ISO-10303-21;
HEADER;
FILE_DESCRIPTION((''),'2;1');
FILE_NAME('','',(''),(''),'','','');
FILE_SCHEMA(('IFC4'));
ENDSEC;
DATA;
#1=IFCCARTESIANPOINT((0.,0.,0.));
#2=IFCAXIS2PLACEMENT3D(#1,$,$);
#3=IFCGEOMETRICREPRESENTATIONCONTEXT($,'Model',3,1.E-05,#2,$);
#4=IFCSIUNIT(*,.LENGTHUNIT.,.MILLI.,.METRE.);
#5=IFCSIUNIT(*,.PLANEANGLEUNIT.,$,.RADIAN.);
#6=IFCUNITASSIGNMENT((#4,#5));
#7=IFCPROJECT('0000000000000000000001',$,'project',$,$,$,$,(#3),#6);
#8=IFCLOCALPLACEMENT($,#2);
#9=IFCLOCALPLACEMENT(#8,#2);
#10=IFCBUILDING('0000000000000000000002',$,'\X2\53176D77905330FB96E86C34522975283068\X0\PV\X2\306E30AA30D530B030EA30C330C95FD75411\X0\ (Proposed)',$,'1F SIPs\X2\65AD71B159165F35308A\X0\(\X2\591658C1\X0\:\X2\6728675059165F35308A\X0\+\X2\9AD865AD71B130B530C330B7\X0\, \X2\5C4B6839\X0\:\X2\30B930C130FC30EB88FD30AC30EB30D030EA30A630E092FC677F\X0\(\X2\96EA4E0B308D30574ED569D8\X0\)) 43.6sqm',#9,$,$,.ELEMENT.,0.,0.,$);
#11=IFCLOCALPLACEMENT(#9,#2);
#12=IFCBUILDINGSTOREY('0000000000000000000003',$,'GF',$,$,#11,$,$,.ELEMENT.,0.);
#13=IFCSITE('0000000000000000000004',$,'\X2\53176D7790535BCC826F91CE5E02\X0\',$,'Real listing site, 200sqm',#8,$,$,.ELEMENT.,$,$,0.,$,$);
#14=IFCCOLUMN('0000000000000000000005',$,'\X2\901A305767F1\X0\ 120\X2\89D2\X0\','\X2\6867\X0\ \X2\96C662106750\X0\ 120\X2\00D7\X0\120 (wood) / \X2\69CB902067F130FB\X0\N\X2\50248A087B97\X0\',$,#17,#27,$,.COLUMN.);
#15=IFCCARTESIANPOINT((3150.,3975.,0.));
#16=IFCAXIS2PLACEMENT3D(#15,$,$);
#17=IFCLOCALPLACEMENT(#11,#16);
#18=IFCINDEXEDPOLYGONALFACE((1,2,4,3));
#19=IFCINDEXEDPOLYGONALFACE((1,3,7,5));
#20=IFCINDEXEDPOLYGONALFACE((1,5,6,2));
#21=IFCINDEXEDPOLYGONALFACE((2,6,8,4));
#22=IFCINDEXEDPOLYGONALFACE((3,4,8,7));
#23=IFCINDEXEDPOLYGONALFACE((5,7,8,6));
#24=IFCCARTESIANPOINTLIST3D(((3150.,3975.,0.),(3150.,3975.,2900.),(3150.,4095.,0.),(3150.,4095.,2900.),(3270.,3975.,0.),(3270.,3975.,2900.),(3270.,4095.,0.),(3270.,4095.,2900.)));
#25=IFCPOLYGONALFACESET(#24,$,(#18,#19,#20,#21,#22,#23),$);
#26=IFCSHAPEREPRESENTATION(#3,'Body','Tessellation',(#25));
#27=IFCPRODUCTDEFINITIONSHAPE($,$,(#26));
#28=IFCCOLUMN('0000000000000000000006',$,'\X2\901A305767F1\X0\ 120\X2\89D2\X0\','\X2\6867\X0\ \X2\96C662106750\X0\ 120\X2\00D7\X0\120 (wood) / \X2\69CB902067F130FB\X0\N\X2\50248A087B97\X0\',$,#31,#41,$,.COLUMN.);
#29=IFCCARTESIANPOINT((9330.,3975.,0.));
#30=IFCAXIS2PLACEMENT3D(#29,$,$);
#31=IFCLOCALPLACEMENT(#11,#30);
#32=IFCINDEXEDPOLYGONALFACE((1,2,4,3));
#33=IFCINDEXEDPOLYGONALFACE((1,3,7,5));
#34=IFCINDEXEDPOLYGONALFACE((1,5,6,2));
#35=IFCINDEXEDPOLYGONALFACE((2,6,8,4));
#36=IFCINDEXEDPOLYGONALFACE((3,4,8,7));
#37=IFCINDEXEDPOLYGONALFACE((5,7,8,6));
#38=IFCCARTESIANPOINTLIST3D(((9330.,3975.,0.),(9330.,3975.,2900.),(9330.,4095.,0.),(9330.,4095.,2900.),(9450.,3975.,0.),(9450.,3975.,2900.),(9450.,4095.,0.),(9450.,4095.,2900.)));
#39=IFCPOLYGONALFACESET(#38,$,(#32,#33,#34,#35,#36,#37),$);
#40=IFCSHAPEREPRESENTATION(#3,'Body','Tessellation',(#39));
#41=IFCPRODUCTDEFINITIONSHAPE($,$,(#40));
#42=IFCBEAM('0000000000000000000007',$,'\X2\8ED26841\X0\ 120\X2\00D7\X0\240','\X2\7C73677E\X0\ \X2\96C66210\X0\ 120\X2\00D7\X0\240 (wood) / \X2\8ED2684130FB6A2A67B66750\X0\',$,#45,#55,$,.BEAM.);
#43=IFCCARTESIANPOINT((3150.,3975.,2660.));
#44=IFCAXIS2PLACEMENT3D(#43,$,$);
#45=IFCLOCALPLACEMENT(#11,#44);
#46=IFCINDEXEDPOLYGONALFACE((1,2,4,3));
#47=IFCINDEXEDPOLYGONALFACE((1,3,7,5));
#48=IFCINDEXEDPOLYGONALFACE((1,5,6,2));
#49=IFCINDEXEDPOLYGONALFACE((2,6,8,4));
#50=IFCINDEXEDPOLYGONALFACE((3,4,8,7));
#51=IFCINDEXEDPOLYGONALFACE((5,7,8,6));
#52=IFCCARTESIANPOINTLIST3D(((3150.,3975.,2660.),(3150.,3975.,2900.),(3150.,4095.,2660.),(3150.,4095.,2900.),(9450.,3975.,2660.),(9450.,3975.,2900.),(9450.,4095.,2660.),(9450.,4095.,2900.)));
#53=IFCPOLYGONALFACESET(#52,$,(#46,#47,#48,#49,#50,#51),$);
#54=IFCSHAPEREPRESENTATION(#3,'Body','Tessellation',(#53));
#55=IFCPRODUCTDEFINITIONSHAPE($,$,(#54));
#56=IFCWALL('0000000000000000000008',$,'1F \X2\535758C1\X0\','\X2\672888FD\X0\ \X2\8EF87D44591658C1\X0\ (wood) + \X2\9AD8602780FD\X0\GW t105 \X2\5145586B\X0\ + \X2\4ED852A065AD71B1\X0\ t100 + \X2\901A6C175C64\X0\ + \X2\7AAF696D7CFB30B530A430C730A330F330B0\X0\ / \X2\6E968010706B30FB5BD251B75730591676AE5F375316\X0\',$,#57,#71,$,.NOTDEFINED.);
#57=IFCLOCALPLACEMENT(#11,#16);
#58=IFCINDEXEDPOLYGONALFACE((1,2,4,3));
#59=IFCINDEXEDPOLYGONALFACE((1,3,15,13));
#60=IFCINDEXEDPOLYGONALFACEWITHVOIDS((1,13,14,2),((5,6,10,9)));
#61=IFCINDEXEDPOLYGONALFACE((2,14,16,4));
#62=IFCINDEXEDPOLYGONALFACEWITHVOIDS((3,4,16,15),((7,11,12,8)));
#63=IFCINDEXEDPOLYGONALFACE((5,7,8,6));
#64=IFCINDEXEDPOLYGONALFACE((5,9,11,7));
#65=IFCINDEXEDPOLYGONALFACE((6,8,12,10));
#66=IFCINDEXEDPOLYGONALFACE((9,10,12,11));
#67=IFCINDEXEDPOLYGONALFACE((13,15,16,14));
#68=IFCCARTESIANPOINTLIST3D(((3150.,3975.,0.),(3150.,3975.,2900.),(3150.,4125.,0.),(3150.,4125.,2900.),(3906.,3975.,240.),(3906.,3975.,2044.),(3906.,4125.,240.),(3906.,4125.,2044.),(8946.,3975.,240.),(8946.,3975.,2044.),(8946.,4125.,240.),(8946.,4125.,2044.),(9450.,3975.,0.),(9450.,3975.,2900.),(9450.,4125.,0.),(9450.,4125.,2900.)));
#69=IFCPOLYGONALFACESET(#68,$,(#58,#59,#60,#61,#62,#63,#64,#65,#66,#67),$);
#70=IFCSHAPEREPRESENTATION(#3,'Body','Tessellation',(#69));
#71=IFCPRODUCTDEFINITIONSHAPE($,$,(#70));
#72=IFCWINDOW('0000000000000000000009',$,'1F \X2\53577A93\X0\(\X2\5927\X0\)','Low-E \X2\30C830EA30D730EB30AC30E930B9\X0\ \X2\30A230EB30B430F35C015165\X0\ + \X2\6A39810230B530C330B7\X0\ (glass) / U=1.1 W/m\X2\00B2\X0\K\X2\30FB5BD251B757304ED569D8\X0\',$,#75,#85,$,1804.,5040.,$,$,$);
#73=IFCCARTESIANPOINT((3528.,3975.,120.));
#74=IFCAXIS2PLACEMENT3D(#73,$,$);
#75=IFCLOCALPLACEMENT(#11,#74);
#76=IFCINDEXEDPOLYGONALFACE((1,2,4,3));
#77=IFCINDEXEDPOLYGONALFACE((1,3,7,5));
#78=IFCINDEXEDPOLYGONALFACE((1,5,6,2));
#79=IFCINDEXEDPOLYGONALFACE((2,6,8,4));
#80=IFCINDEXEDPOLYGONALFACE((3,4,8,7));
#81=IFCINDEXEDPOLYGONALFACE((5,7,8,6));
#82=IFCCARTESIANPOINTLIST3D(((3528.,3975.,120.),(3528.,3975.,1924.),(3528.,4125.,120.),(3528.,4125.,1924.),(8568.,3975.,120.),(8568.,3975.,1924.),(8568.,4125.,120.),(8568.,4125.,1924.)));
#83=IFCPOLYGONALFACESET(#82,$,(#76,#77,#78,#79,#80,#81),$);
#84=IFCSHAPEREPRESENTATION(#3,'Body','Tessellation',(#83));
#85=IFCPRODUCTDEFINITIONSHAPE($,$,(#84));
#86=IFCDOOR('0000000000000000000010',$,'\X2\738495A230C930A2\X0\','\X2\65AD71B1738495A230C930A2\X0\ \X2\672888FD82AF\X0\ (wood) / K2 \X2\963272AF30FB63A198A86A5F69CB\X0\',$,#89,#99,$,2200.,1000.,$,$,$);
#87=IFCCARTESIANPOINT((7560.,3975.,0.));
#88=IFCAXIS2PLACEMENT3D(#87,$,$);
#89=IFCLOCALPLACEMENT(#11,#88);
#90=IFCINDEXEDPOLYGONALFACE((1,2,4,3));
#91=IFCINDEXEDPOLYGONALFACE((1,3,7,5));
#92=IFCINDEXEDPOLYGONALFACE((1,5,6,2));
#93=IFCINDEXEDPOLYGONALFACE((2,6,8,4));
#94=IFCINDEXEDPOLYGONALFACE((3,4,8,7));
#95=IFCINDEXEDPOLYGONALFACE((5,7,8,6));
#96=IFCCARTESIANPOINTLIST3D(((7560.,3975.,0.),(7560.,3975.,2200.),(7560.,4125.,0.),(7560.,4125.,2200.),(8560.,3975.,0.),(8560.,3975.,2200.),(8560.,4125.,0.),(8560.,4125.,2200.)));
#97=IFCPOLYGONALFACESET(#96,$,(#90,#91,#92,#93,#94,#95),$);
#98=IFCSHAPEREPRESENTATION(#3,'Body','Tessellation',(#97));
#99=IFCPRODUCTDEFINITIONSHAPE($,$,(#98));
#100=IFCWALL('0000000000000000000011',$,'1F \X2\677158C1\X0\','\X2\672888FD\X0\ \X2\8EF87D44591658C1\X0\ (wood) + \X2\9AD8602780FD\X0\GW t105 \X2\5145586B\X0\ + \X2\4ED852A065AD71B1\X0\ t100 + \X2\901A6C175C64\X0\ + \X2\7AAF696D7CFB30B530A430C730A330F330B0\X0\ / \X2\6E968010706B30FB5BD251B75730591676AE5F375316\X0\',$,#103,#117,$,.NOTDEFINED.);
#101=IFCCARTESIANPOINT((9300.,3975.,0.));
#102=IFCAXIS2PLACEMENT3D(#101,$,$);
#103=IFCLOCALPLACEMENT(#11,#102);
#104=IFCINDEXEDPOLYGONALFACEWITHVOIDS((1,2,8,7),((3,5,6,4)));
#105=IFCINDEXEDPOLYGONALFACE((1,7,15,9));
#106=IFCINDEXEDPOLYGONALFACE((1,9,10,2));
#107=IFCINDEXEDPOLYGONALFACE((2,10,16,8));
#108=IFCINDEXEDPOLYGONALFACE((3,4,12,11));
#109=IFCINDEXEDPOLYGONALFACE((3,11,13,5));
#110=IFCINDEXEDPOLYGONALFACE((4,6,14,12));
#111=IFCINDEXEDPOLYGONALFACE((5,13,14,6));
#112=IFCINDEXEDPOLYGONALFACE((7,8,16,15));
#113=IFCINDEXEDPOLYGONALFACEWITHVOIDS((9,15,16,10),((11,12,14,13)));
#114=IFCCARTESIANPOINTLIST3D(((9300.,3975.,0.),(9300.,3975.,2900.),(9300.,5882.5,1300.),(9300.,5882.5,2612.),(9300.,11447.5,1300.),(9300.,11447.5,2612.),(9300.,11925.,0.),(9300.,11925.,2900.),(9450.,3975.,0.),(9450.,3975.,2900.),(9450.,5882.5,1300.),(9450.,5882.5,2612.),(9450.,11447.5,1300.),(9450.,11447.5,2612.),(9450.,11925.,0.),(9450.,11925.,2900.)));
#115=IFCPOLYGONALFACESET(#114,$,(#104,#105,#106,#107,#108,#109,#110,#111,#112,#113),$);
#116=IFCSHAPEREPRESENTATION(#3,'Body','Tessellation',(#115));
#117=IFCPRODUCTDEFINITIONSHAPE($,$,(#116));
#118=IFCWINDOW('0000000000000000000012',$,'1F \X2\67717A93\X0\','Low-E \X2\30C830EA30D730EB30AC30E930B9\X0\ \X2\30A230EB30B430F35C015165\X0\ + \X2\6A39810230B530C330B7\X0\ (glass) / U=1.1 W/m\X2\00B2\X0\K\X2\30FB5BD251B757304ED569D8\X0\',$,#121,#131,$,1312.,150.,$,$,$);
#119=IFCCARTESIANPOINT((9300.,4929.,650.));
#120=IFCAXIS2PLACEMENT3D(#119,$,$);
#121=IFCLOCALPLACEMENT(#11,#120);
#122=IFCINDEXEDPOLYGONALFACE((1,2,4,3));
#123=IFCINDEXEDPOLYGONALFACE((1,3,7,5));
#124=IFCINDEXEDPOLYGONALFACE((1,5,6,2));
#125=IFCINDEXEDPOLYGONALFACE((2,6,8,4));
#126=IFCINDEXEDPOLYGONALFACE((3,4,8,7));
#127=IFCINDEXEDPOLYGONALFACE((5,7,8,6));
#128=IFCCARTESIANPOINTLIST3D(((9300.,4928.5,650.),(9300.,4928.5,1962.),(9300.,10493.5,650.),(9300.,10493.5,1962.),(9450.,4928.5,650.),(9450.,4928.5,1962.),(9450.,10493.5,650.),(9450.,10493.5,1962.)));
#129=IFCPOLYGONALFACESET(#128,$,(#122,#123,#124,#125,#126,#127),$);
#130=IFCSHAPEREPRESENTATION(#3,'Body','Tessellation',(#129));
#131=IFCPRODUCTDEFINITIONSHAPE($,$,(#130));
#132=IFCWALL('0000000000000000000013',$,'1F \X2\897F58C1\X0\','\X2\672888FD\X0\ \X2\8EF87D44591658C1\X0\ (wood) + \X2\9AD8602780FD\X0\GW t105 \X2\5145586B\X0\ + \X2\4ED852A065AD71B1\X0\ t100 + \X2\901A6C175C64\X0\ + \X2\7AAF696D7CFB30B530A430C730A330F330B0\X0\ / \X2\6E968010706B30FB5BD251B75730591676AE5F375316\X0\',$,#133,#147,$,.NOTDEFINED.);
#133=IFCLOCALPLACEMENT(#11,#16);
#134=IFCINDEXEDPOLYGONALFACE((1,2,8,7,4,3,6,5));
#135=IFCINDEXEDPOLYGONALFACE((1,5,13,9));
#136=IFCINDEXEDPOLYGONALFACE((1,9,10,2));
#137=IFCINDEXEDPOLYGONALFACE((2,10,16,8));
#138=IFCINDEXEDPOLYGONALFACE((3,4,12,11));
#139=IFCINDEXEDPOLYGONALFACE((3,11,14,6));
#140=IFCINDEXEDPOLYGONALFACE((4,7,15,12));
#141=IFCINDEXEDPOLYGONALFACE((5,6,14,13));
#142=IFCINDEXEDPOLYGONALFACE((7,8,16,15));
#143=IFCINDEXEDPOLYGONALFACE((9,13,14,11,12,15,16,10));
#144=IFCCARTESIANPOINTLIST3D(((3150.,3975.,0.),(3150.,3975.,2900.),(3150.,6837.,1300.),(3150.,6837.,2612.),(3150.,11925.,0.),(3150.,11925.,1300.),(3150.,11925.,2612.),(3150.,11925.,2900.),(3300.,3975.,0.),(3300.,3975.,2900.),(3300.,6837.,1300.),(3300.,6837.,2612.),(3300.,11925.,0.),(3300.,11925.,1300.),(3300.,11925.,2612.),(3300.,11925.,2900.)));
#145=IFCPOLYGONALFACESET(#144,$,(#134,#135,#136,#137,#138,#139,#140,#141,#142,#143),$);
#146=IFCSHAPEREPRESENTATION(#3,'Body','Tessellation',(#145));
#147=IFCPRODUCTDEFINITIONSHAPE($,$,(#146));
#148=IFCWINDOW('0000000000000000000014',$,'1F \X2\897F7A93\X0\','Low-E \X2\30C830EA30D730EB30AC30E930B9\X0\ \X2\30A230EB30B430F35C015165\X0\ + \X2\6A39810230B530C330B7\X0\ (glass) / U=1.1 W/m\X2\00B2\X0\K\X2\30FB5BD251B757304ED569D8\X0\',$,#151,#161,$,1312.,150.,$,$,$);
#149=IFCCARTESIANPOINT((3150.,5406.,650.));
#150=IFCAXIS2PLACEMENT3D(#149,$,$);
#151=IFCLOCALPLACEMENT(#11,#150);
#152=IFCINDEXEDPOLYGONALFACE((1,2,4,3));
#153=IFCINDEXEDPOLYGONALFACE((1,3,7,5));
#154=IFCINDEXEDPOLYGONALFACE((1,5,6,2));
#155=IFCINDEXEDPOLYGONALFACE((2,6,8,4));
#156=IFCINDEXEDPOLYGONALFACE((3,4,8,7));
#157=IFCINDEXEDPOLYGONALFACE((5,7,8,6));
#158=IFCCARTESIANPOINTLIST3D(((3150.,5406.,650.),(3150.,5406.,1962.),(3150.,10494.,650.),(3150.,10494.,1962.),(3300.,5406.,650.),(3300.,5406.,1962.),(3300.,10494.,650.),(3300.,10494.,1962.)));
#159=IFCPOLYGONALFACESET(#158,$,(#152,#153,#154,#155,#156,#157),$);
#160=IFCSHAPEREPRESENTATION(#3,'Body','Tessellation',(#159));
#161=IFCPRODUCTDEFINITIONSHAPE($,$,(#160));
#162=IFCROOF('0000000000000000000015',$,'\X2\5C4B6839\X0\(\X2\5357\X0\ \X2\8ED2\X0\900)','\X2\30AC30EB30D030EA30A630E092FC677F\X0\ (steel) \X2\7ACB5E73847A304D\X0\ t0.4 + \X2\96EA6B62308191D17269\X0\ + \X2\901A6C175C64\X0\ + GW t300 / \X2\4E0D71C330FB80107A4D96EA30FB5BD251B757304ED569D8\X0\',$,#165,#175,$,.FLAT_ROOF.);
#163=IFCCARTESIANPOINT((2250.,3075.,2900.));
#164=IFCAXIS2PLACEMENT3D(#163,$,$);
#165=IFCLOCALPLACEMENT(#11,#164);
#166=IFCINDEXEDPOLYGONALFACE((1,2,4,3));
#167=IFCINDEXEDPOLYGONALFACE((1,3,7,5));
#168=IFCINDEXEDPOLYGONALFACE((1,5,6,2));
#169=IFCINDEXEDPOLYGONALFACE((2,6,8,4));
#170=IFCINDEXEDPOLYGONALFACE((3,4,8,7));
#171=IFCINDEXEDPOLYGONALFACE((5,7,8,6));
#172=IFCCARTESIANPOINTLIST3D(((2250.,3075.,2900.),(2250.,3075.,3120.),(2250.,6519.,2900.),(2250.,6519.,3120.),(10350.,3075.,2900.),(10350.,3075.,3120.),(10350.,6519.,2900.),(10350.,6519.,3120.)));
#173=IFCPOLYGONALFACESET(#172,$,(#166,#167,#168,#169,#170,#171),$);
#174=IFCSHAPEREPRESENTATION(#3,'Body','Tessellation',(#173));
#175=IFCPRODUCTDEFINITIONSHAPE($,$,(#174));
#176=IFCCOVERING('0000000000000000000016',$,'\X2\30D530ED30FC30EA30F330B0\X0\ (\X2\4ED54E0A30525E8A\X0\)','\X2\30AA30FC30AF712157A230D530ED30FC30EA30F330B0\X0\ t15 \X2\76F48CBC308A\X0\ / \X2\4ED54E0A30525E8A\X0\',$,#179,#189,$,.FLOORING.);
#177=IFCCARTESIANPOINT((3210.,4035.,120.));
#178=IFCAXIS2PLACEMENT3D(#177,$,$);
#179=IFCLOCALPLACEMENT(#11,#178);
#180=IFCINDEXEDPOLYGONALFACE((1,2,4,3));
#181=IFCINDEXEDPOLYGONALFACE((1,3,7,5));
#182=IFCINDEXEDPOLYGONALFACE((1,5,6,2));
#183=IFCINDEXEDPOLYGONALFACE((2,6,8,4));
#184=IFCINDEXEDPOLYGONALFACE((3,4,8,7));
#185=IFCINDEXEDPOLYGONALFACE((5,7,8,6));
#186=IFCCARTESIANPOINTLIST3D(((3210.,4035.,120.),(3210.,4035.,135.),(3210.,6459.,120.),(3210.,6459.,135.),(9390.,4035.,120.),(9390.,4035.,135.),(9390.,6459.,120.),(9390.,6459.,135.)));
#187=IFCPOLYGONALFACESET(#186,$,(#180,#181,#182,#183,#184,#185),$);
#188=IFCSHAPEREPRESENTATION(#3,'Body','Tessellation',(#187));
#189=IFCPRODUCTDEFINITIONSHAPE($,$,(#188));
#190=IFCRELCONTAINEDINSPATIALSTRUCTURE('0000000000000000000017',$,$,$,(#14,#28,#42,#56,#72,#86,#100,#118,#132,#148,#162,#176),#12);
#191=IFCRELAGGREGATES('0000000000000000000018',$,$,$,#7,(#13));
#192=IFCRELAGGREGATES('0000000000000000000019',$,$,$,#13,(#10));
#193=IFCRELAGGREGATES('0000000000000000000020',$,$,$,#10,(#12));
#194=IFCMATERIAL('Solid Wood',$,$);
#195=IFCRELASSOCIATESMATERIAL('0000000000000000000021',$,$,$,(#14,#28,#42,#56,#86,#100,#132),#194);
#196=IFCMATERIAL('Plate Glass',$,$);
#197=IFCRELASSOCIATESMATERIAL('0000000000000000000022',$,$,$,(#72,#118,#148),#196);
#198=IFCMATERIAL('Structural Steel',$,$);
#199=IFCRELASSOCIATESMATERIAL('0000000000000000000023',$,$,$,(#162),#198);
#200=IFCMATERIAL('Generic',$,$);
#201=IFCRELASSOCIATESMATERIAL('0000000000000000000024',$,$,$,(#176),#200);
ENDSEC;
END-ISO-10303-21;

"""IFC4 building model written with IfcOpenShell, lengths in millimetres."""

from ifc_helpers import new_model, si_unit, frame, frame_2d, origin, place, context, project, spatial, rectangle, extrude, material, element, fill, save


model = new_model("IFC4")

# Units and contexts
model_context = context("Model", 3, precision=1e-05, world=origin())
ifc_project = project(units=[si_unit("LENGTHUNIT", "METRE", prefix="MILLI"), si_unit("PLANEANGLEUNIT", "RADIAN")], contexts=[model_context])

# Site, building, storey
site_placement = place(None, origin())
site = spatial("IfcSite", under=ifc_project, at=site_placement, Name="北海道富良野市", ObjectType="Real listing site, 200sqm", CompositionType="ELEMENT", RefElevation=0.0)
building_placement = place(site_placement, origin())
building = spatial("IfcBuilding", under=site, at=building_placement, Name="北海道・雨水利用とPVのオフグリッド志向 (Proposed)", ObjectType="1F SIPs断熱外張り(外壁:木材外張り+高断熱サッシ, 屋根:スチール製ガルバリウム鋼板(雪下ろし仕様)) 43.6sqm", CompositionType="ELEMENT", ElevationOfRefHeight=0.0, ElevationOfTerrain=0.0)
storey_placement = place(building_placement, origin())
storey = spatial("IfcBuildingStorey", under=building, at=storey_placement, Name="GF", CompositionType="ELEMENT", Elevation=0.0)

# Columns
ifc_material_1 = material(Name="Solid Wood")
column_1_placement = place(storey_placement, frame((3150.0, 3975.0, 0.0)))
element("IfcColumn", 1, at=column_1_placement, inside=storey, material=ifc_material_1, Name="通し柱 120角", Description="桧 集成材 120×120 (wood) / 構造柱・N値計算", PredefinedType="COLUMN", context=model_context, shape_type="SweptSolid", body=[
    extrude(rectangle(XDim=120.0, YDim=120.0, at=frame_2d((60.0, 60.0))), frame((3150.0, 3975.0, 0.0)), (0.0, 0.0, 1.0), 2900.0),
])
column_2_placement = place(storey_placement, frame((9330.0, 3975.0, 0.0)))
element("IfcColumn", 2, at=column_2_placement, inside=storey, material=ifc_material_1, Name="通し柱 120角", Description="桧 集成材 120×120 (wood) / 構造柱・N値計算", PredefinedType="COLUMN", context=model_context, shape_type="SweptSolid", body=[
    extrude(rectangle(XDim=120.0, YDim=120.0, at=frame_2d((60.0, 60.0))), frame((9330.0, 3975.0, 0.0)), (0.0, 0.0, 1.0), 2900.0),
])

# Beam
beam_1_placement = place(storey_placement, frame((3150.0, 3975.0, 2660.0)))
element("IfcBeam", 3, at=beam_1_placement, inside=storey, material=ifc_material_1, Name="軒桁 120×240", Description="米松 集成 120×240 (wood) / 軒桁・横架材", PredefinedType="BEAM", context=model_context, shape_type="SweptSolid", body=[
    extrude(rectangle(XDim=6300.0, YDim=120.0, at=frame_2d((3150.0, 60.0))), frame((3150.0, 3975.0, 2660.0)), (0.0, 0.0, 1.0), 240.0),
])

# Wall, openings, window, door
wall_1_placement = place(storey_placement, frame((3150.0, 3975.0, 0.0)))
wall_1 = element("IfcWall", 4, at=wall_1_placement, inside=storey, material=ifc_material_1, Name="1F 南壁", Description="木製 軸組外壁 (wood) + 高性能GW t105 充填 + 付加断熱 t100 + 通気層 + 窯業系サイディング / 準耐火・寒冷地外皮強化", PredefinedType="NOTDEFINED", context=model_context, shape_type="SweptSolid", body=[
    extrude(rectangle(XDim=6300.0, YDim=150.0, at=frame_2d((3150.0, 75.0))), frame((3150.0, 3975.0, 0.0)), (0.0, 0.0, 1.0), 2900.0),
])
opening_1_placement = place(storey_placement, frame((3528.0, 3975.0, 120.0)))
opening_1 = element("IfcOpeningElement", 5, at=opening_1_placement, cuts=wall_1, PredefinedType="NOTDEFINED", context=model_context, shape_type="SweptSolid", body=[
    extrude(rectangle(XDim=5040.0, YDim=150.0, at=frame_2d((2520.0, 75.0))), frame((3528.0, 3975.0, 120.0)), (0.0, 0.0, 1.0), 1804.0),
])
opening_2_placement = place(storey_placement, frame((7560.0, 3975.0, 0.0)))
opening_2 = element("IfcOpeningElement", 6, at=opening_2_placement, cuts=wall_1, PredefinedType="NOTDEFINED", context=model_context, shape_type="SweptSolid", body=[
    extrude(rectangle(XDim=1000.0, YDim=150.0, at=frame_2d((500.0, 75.0))), frame((7560.0, 3975.0, 0.0)), (0.0, 0.0, 1.0), 2200.0),
])
ifc_material_2 = material(Name="Plate Glass")
window_1_placement = place(storey_placement, frame((3528.0, 3975.0, 120.0)))
window_1 = element("IfcWindow", 7, at=window_1_placement, inside=storey, material=ifc_material_2, Name="1F 南窓(大)", Description="Low-E トリプルガラス アルゴン封入 + 樹脂サッシ (glass) / U=1.1 W/m²K・寒冷地仕様", OverallHeight=1804.0, OverallWidth=5040.0, context=model_context, shape_type="SweptSolid", body=[
    extrude(rectangle(XDim=5040.0, YDim=150.0, at=frame_2d((2520.0, 75.0))), frame((3528.0, 3975.0, 120.0)), (0.0, 0.0, 1.0), 1804.0),
])
fill(opening_1, window_1)
door_placement = place(storey_placement, frame((7560.0, 3975.0, 0.0)))
door = element("IfcDoor", 8, at=door_placement, inside=storey, material=ifc_material_1, Name="玄関ドア", Description="断熱玄関ドア 木製芯 (wood) / K2 防犯・採風機構", OverallHeight=2200.0, OverallWidth=1000.0, context=model_context, shape_type="SweptSolid", body=[
    extrude(rectangle(XDim=1000.0, YDim=150.0, at=frame_2d((500.0, 75.0))), frame((7560.0, 3975.0, 0.0)), (0.0, 0.0, 1.0), 2200.0),
])
fill(opening_2, door)

# Walls, openings, windows
wall_2_placement = place(storey_placement, frame((9300.0, 3975.0, 0.0)))
wall_2 = element("IfcWall", 9, at=wall_2_placement, inside=storey, material=ifc_material_1, Name="1F 東壁", Description="木製 軸組外壁 (wood) + 高性能GW t105 充填 + 付加断熱 t100 + 通気層 + 窯業系サイディング / 準耐火・寒冷地外皮強化", PredefinedType="NOTDEFINED", context=model_context, shape_type="SweptSolid", body=[
    extrude(rectangle(XDim=150.0, YDim=7950.0, at=frame_2d((75.0, 3975.0))), frame((9300.0, 3975.0, 0.0)), (0.0, 0.0, 1.0), 2900.0),
])
opening_3_placement = place(storey_placement, frame((9300.0, 4929.0, 650.0)))
opening_3 = element("IfcOpeningElement", 10, at=opening_3_placement, cuts=wall_2, PredefinedType="NOTDEFINED", context=model_context, shape_type="SweptSolid", body=[
    extrude(rectangle(XDim=150.0, YDim=5565.0, at=frame_2d((75.0, 2782.0))), frame((9300.0, 4929.0, 650.0)), (0.0, 0.0, 1.0), 1312.0),
])
window_2_placement = place(storey_placement, frame((9300.0, 4929.0, 650.0)))
window_2 = element("IfcWindow", 11, at=window_2_placement, inside=storey, material=ifc_material_2, Name="1F 東窓", Description="Low-E トリプルガラス アルゴン封入 + 樹脂サッシ (glass) / U=1.1 W/m²K・寒冷地仕様", OverallHeight=1312.0, OverallWidth=150.0, context=model_context, shape_type="SweptSolid", body=[
    extrude(rectangle(XDim=150.0, YDim=5565.0, at=frame_2d((75.0, 2782.0))), frame((9300.0, 4929.0, 650.0)), (0.0, 0.0, 1.0), 1312.0),
])
fill(opening_3, window_2)
wall_3_placement = place(storey_placement, frame((3150.0, 3975.0, 0.0)))
wall_3 = element("IfcWall", 12, at=wall_3_placement, inside=storey, material=ifc_material_1, Name="1F 西壁", Description="木製 軸組外壁 (wood) + 高性能GW t105 充填 + 付加断熱 t100 + 通気層 + 窯業系サイディング / 準耐火・寒冷地外皮強化", PredefinedType="NOTDEFINED", context=model_context, shape_type="SweptSolid", body=[
    extrude(rectangle(XDim=150.0, YDim=7950.0, at=frame_2d((75.0, 3975.0))), frame((3150.0, 3975.0, 0.0)), (0.0, 0.0, 1.0), 2900.0),
])
opening_4_placement = place(storey_placement, frame((3150.0, 5406.0, 650.0)))
opening_4 = element("IfcOpeningElement", 13, at=opening_4_placement, cuts=wall_3, PredefinedType="NOTDEFINED", context=model_context, shape_type="SweptSolid", body=[
    extrude(rectangle(XDim=150.0, YDim=5088.0, at=frame_2d((75.0, 2544.0))), frame((3150.0, 5406.0, 650.0)), (0.0, 0.0, 1.0), 1312.0),
])
window_3_placement = place(storey_placement, frame((3150.0, 5406.0, 650.0)))
window_3 = element("IfcWindow", 14, at=window_3_placement, inside=storey, material=ifc_material_2, Name="1F 西窓", Description="Low-E トリプルガラス アルゴン封入 + 樹脂サッシ (glass) / U=1.1 W/m²K・寒冷地仕様", OverallHeight=1312.0, OverallWidth=150.0, context=model_context, shape_type="SweptSolid", body=[
    extrude(rectangle(XDim=150.0, YDim=5088.0, at=frame_2d((75.0, 2544.0))), frame((3150.0, 5406.0, 650.0)), (0.0, 0.0, 1.0), 1312.0),
])
fill(opening_4, window_3)

# Roof
ifc_material_3 = material(Name="Structural Steel")
roof_placement = place(storey_placement, frame((2250.0, 3075.0, 2900.0)))
element("IfcRoof", 15, at=roof_placement, inside=storey, material=ifc_material_3, Name="屋根(南 軒900)", Description="ガルバリウム鋼板 (steel) 立平葺き t0.4 + 雪止め金物 + 通気層 + GW t300 / 不燃・耐積雪・寒冷地仕様", PredefinedType="FLAT_ROOF", context=model_context, shape_type="SweptSolid", body=[
    extrude(rectangle(XDim=8100.0, YDim=3444.0, at=frame_2d((4050.0, 1722.0))), frame((2250.0, 3075.0, 2900.0)), (0.0, 0.0, 1.0), 220.0),
])

# Covering
ifc_material_4 = material(Name="Generic")
covering_1_placement = place(storey_placement, frame((3210.0, 4035.0, 120.0)))
element("IfcCovering", 16, at=covering_1_placement, inside=storey, material=ifc_material_4, Name="フローリング (仕上げ床)", Description="オーク無垢フローリング t15 直貼り / 仕上げ床", PredefinedType="FLOORING", context=model_context, shape_type="SweptSolid", body=[
    extrude(rectangle(XDim=6180.0, YDim=2424.0, at=frame_2d((3090.0, 1212.0))), frame((3210.0, 4035.0, 120.0)), (0.0, 0.0, 1.0), 15.0),
])

save(model, "model.ifc")
